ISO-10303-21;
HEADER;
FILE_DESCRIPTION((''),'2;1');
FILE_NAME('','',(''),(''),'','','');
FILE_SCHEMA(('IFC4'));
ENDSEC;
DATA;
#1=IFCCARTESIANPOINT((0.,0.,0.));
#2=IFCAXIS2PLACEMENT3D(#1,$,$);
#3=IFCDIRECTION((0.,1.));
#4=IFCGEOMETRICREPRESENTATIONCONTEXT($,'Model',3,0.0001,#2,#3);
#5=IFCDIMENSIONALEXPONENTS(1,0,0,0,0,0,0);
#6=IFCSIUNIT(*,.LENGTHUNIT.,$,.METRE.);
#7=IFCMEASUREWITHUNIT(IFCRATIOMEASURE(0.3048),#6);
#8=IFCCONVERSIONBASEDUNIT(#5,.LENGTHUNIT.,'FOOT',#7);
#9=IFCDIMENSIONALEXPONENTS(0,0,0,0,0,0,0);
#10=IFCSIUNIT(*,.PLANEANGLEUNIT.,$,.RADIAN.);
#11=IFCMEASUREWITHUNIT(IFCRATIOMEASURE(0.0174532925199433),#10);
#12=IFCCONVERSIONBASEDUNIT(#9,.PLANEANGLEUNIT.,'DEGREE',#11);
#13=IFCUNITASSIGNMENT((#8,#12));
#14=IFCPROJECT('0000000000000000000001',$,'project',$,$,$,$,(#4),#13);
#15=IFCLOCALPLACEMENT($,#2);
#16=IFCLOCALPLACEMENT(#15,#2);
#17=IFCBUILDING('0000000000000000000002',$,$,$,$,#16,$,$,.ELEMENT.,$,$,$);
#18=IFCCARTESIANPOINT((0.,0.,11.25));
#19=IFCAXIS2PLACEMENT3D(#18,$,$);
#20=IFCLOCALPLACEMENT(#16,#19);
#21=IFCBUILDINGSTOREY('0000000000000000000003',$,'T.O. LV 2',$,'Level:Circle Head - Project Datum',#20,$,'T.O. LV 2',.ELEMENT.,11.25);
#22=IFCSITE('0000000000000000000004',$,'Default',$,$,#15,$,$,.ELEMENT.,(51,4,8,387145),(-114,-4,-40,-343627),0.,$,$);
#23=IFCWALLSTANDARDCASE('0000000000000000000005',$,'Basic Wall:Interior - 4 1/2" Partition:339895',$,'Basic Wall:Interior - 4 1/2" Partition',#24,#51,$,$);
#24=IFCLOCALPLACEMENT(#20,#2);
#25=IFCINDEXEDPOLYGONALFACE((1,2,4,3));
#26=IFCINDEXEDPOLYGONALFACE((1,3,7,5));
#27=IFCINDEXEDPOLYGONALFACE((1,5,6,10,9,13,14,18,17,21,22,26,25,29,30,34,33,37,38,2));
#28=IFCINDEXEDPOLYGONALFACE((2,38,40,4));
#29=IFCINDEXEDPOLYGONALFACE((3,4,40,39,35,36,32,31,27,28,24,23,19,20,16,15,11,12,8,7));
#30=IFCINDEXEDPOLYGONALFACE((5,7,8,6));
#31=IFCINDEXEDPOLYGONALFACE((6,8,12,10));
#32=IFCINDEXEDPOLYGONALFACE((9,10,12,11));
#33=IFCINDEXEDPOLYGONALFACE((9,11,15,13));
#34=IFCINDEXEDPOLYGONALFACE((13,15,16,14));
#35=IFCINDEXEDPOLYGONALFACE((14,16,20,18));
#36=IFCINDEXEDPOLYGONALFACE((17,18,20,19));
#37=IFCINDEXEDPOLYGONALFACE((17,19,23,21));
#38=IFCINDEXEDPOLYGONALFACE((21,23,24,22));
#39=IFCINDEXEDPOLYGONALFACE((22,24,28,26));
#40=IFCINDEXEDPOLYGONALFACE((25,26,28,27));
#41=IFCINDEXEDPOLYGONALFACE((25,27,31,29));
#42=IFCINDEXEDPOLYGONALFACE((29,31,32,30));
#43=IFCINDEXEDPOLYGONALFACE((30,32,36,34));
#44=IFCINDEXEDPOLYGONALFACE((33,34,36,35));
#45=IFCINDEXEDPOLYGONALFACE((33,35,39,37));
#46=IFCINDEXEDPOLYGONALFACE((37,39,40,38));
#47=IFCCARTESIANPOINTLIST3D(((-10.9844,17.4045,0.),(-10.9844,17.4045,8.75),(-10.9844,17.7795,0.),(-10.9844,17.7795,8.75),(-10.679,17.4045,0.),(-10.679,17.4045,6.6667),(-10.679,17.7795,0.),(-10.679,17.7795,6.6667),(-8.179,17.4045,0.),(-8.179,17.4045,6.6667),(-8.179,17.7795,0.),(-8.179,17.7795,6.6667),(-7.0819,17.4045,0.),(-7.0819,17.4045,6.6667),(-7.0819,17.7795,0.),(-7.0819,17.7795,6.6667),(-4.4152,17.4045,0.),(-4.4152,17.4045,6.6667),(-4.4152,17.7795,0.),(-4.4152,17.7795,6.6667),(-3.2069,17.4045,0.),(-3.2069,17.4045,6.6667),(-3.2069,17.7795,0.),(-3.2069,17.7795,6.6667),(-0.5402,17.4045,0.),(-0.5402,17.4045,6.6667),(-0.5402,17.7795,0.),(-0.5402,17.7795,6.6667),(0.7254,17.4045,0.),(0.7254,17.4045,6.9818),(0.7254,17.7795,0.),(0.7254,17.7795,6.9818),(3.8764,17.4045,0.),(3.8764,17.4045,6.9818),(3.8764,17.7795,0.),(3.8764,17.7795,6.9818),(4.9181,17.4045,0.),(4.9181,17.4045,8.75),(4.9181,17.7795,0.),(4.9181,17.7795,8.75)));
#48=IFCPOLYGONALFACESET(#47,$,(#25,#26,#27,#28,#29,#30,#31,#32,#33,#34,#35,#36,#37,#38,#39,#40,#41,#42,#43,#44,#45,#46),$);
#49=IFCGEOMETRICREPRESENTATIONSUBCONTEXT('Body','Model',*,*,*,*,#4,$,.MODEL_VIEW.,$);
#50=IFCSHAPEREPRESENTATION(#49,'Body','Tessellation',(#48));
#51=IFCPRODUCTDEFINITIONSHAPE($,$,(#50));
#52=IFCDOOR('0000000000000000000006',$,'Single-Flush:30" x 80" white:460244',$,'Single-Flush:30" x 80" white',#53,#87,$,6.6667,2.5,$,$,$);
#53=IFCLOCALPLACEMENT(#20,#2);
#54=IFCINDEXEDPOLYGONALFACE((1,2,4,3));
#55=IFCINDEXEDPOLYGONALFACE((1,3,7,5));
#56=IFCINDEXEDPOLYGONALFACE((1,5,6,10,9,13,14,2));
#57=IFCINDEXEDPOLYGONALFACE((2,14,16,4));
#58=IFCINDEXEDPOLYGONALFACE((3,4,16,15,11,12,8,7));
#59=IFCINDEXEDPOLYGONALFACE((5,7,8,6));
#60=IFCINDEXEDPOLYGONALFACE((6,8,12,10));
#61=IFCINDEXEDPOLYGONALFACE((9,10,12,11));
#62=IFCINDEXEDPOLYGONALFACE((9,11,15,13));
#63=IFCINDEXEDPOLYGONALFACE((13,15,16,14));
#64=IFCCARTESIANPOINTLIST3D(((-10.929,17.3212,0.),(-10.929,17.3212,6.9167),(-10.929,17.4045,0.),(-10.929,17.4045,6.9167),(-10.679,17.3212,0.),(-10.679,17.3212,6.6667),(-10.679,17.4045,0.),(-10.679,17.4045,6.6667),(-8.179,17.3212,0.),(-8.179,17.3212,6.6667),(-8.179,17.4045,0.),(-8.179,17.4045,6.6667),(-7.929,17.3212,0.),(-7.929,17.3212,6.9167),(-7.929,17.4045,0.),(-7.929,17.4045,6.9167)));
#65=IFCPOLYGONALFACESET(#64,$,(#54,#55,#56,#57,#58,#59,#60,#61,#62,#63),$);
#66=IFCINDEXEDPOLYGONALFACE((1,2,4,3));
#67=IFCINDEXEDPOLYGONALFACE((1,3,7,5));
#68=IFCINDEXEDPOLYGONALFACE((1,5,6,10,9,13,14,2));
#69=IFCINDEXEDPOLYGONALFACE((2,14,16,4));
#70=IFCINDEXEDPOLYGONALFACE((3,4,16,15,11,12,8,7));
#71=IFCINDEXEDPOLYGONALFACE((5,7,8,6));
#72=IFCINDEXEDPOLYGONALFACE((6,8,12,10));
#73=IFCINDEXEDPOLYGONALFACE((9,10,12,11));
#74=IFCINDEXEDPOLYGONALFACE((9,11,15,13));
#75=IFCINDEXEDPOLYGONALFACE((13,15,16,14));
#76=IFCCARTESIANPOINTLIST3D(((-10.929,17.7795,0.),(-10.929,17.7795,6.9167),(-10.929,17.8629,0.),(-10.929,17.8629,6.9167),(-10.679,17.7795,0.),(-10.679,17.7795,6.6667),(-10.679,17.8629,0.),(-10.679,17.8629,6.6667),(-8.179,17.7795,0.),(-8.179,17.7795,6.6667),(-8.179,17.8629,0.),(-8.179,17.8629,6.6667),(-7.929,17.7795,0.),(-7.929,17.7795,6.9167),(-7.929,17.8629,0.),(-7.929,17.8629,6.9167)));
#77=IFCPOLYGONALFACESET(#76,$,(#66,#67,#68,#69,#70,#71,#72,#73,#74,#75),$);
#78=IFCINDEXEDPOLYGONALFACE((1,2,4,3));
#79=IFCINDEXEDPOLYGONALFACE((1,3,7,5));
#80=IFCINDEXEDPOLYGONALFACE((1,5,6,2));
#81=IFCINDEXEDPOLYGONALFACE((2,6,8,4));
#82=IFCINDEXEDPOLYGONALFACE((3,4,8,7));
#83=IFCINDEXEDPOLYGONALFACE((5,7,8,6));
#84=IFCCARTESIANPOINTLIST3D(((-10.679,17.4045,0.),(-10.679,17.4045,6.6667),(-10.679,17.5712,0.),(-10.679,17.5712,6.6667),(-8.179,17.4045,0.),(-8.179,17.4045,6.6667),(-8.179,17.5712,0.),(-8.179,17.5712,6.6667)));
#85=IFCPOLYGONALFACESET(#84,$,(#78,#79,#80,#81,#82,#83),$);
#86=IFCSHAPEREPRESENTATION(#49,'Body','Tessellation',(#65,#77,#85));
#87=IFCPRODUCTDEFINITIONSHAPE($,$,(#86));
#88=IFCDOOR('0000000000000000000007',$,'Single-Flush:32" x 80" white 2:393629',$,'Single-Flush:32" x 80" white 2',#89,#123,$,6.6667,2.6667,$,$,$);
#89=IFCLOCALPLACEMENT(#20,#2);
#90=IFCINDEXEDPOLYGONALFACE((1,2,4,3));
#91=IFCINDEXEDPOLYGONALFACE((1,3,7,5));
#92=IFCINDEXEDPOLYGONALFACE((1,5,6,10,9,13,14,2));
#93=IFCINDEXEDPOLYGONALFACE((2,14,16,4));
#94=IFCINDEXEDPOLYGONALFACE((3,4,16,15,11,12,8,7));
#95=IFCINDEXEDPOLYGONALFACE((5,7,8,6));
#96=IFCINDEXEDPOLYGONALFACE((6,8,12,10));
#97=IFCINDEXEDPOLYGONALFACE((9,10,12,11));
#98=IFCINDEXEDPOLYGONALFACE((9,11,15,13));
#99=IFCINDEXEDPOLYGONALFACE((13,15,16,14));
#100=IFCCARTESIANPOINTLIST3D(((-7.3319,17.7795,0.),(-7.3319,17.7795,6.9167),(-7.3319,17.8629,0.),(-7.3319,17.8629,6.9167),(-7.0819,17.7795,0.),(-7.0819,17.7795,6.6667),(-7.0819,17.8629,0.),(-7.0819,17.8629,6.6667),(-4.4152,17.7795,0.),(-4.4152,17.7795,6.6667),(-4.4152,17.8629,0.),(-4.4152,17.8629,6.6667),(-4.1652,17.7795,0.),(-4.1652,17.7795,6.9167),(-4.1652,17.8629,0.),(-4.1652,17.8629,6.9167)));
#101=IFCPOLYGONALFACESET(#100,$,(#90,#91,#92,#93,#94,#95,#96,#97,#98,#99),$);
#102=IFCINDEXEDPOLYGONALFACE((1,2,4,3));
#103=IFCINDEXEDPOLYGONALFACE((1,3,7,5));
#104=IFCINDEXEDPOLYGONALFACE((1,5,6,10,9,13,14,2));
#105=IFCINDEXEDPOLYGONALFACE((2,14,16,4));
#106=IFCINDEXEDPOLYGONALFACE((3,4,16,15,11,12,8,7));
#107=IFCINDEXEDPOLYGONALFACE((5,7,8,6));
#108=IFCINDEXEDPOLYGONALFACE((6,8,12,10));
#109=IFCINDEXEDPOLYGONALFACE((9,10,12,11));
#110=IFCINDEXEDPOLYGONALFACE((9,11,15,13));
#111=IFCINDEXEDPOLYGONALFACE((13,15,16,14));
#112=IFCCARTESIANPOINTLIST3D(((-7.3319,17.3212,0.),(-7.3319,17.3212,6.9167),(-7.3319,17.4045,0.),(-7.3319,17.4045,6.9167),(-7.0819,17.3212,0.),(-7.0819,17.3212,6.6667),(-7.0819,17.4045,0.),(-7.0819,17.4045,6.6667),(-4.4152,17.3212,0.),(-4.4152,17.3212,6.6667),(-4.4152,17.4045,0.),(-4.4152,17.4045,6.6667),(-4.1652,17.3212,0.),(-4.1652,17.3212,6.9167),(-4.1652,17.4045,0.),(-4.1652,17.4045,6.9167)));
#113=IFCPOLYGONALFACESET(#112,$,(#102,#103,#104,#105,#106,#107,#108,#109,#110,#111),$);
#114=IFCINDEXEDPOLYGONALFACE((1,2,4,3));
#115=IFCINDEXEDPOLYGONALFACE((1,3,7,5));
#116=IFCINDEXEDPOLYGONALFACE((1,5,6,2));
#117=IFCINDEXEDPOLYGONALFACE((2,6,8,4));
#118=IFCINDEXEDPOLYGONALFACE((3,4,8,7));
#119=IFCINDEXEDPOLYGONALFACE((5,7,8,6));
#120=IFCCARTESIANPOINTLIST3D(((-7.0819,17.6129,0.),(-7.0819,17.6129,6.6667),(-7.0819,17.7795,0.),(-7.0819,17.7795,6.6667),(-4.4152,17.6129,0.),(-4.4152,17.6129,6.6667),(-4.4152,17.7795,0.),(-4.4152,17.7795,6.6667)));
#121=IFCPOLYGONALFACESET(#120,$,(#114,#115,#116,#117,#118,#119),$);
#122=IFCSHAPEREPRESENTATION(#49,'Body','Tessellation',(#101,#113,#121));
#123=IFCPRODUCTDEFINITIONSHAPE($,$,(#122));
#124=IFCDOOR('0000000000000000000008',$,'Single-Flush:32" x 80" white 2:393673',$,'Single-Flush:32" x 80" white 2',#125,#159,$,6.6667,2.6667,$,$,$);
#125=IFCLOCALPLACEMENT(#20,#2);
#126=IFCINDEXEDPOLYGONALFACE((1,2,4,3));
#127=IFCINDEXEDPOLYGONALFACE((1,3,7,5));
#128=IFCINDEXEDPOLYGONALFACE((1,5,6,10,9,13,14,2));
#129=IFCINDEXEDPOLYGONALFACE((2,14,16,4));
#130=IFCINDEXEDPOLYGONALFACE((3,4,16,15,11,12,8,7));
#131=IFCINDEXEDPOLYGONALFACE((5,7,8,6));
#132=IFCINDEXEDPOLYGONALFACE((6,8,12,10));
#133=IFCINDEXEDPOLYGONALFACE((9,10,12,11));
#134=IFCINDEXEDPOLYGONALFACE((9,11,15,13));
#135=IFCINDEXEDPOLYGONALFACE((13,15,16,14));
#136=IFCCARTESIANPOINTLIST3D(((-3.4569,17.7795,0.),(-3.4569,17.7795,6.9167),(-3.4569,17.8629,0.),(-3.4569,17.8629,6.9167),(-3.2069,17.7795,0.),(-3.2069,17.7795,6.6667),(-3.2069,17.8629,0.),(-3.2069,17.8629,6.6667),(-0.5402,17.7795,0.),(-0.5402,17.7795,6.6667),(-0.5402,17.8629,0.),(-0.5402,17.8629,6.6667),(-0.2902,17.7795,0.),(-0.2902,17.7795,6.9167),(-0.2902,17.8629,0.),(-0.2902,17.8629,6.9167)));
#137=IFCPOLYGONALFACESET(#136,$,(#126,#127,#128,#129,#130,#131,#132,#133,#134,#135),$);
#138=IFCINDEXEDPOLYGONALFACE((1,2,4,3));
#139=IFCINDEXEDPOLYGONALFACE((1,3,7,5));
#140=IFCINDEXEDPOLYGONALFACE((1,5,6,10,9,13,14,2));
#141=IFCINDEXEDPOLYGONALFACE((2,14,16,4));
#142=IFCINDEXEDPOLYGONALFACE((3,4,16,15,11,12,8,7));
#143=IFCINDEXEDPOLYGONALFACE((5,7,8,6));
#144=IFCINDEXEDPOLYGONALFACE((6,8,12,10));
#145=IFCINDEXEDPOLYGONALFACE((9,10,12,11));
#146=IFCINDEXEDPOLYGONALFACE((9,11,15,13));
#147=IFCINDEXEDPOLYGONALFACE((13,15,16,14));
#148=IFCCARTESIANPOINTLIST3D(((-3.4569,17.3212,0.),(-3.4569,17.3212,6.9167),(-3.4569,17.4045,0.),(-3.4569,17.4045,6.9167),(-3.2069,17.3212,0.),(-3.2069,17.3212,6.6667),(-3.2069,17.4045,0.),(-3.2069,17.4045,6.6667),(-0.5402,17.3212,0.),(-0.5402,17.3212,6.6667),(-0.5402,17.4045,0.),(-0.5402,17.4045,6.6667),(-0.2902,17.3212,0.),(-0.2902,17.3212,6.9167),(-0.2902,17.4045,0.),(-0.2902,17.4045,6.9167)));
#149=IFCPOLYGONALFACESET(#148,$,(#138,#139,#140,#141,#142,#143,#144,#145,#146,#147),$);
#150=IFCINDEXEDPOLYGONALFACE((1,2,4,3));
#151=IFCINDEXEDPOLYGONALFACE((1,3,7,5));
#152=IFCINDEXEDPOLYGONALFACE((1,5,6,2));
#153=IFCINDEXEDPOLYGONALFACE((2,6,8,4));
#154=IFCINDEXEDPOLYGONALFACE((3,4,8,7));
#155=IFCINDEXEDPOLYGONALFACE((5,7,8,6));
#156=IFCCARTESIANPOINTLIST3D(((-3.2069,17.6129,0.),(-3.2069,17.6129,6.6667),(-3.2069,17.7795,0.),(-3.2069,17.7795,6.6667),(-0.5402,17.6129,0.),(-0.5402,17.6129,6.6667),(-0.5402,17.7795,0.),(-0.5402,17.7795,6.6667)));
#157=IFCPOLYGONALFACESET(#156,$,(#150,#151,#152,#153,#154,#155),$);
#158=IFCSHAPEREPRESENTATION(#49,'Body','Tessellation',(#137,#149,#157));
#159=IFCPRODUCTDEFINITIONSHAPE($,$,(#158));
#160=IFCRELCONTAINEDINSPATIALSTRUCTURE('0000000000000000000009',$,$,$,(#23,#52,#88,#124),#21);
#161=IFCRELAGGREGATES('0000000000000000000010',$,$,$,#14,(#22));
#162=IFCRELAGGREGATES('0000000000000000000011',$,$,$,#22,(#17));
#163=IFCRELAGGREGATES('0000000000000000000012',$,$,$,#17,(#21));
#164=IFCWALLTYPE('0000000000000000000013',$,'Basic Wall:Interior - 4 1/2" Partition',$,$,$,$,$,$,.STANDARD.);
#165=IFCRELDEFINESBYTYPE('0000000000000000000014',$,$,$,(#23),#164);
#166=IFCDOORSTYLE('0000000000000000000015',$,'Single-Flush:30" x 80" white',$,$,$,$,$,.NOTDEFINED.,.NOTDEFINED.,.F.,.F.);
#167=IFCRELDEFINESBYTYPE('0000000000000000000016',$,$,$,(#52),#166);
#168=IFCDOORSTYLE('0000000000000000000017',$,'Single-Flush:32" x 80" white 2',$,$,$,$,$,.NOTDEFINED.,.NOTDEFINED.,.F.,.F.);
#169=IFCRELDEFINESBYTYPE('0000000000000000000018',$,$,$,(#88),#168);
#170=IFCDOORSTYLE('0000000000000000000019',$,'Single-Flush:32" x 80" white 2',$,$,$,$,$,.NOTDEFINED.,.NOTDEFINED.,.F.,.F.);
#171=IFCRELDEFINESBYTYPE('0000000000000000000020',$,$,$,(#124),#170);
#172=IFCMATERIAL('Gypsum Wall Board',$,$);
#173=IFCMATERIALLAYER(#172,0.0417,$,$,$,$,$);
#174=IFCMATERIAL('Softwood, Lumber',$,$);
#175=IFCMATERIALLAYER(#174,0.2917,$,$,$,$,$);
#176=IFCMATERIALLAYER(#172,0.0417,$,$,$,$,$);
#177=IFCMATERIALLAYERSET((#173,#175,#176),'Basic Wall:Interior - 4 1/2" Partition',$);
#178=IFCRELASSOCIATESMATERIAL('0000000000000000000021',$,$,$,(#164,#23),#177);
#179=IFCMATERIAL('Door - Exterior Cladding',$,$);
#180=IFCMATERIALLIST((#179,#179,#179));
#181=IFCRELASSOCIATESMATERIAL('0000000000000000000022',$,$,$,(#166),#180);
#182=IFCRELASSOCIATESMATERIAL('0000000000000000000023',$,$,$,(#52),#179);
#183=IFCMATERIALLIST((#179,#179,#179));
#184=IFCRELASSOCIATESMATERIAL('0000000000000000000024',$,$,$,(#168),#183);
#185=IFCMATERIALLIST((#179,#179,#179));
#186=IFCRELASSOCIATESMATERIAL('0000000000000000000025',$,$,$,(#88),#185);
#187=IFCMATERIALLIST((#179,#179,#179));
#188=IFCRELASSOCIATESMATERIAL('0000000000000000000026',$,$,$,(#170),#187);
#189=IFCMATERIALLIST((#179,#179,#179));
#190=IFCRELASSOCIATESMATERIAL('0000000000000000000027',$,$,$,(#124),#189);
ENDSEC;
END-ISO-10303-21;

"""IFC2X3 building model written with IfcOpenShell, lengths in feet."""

from ifc_helpers import new_model, entity, si_unit, converted_unit, direction, frame, frame_2d, origin, origin_2d_with_axis, place, context, subcontext, project, spatial, polyline, rectangle, outline, extrude, source, transform, mapped, material, material_list, layer, layer_set, layer_usage, type_object, type_shapes, element, fill, save


model = new_model("IFC2X3")

# Units and contexts
model_context = context("Model", 3, precision=0.0001, world=origin(), true_north=direction((0.0, 1.0)))
body_context = subcontext(model_context, "Body", "Model", "MODEL_VIEW")
ifc_project = project(units=[converted_unit("LENGTHUNIT", "FOOT", entity("IfcRatioMeasure", 0.3048), si_unit("LENGTHUNIT", "METRE"), dimensions=[1, 0, 0, 0, 0, 0, 0]), converted_unit("PLANEANGLEUNIT", "DEGREE", entity("IfcRatioMeasure", 0.0174532925199433), si_unit("PLANEANGLEUNIT", "RADIAN"), dimensions=[0, 0, 0, 0, 0, 0, 0])], contexts=[model_context])

# Site, building, storey
site_placement = place(None, origin())
site = spatial("IfcSite", under=ifc_project, at=site_placement, Name="Default", CompositionType="ELEMENT", RefLatitude=(51, 4, 8, 387145), RefLongitude=(-114, -4, -40, -343627), RefElevation=0.0)
building_placement = place(site_placement, origin())
building = spatial("IfcBuilding", under=site, at=building_placement, CompositionType="ELEMENT")
storey_placement = place(building_placement, frame((0.0, 0.0, 11.25)))
storey = spatial("IfcBuildingStorey", under=building, at=storey_placement, Name="T.O. LV 2", ObjectType="Level:Circle Head - Project Datum", LongName="T.O. LV 2", CompositionType="ELEMENT", Elevation=11.25)

# Wall, openings, doors
ifc_material_1 = material(Name="Gypsum Wall Board")
ifc_layer_1 = layer(ifc_material_1, 0.0417)
ifc_material_2 = material(Name="Softwood, Lumber")
ifc_layer_2 = layer(ifc_material_2, 0.2917)
ifc_layer_3 = layer(ifc_material_1, 0.0417)
ifc_layer_set_1 = layer_set([ifc_layer_1, ifc_layer_2, ifc_layer_3], Name="Basic Wall:Interior - 4 1/2\" Partition")
ifc_layer_usage_1 = layer_usage(ifc_layer_set_1, "AXIS2", "NEGATIVE", 0.1875)
wall_type_1 = type_object("IfcWallType", Name="Basic Wall:Interior - 4 1/2\" Partition", PredefinedType="STANDARD", material=ifc_layer_set_1)
wall_1_placement = place(storey_placement, frame((4.9181, 17.592, 0.0), z_axis=(0.0, 0.0, 1.0), x_axis=(-1.0, 0.0, 0.0)))
wall_1 = element("IfcWallStandardCase", 1, at=wall_1_placement, inside=storey, type_object=wall_type_1, material=ifc_layer_usage_1, Name="Basic Wall:Interior - 4 1/2\" Partition:339895", ObjectType="Basic Wall:Interior - 4 1/2\" Partition", context=body_context, shape_type="SweptSolid", body=[
    extrude(rectangle(XDim=15.9025, YDim=0.375, at=frame_2d((7.9512, 0.0), x_axis=(1.0, 0.0))), origin(), (0.0, 0.0, 1.0), 8.75),
])
opening_1_placement = place(wall_1_placement, frame((12.0, 0.1875, 0.0)))
opening_1 = element("IfcOpeningElement", 2, at=opening_1_placement, cuts=wall_1, ObjectType="Opening", context=body_context, shape_type="SweptSolid", body=[
    extrude(rectangle(XDim=2.6667, YDim=6.6667, at=frame_2d((3.3333, 1.3333), x_axis=(0.0, 1.0))), frame((0.0, 0.0, 0.0), z_axis=(0.0, -1.0, 0.0), x_axis=(0.0, 0.0, 1.0)), (0.0, 0.0, 1.0), 0.375),
])
opening_2_placement = place(wall_1_placement, frame((8.125, 0.1875, 0.0)))
opening_2 = element("IfcOpeningElement", 3, at=opening_2_placement, cuts=wall_1, ObjectType="Opening", context=body_context, shape_type="SweptSolid", body=[
    extrude(rectangle(XDim=2.6667, YDim=6.6667, at=frame_2d((3.3333, 1.3333), x_axis=(0.0, -1.0))), frame((0.0, 0.0, 0.0), z_axis=(0.0, -1.0, 0.0), x_axis=(0.0, 0.0, 1.0)), (0.0, 0.0, 1.0), 0.375),
])
opening_3_placement = place(wall_1_placement, frame((1.0417, -0.1875, 0.0)))
element("IfcOpeningElement", 4, at=opening_3_placement, cuts=wall_1, ObjectType="Opening", context=body_context, shape_type="SweptSolid", body=[
    extrude(rectangle(XDim=6.9818, YDim=3.151, at=frame_2d((3.4909, 1.5755), x_axis=(1.0, 0.0))), frame((0.0, 0.0, 0.0), z_axis=(0.0, 1.0, 0.0), x_axis=(0.0, 0.0, 1.0)), (0.0, 0.0, 1.0), 0.375),
])
opening_4_placement = place(wall_1_placement, frame((13.0971, -0.1875, 0.0)))
opening_4 = element("IfcOpeningElement", 5, at=opening_4_placement, cuts=wall_1, ObjectType="Opening", context=body_context, shape_type="SweptSolid", body=[
    extrude(rectangle(XDim=2.5, YDim=6.6667, at=frame_2d((3.3333, 1.25), x_axis=(0.0, 1.0))), frame((0.0, 0.0, 0.0), z_axis=(0.0, 1.0, 0.0), x_axis=(0.0, 0.0, 1.0)), (0.0, 0.0, 1.0), 0.375),
])
ifc_material_3 = material(Name="Door - Exterior Cladding")
ifc_material_list_1 = material_list([ifc_material_3, ifc_material_3, ifc_material_3])
door_style_1 = type_object("IfcDoorStyle", Name="Single-Flush:30\" x 80\" white", ConstructionType="NOTDEFINED", OperationType="NOTDEFINED", ParameterTakesPrecedence=False, Sizeable=False, material=ifc_material_list_1)
shared_shape_1 = source(origin(), body_context, "Body", "SweptSolid", [
    extrude(outline(polyline([(-1.5, -3.5208), (1.5, -3.5208), (1.5, 3.3958), (1.25, 3.3958), (1.25, -3.2708), (-1.25, -3.2708), (-1.25, 3.3958), (-1.5, 3.3958), (-1.5, -3.5208)])), frame((1.25, 0.375, 3.3958), z_axis=(0.0, 1.0, 0.0), x_axis=(1.0, 0.0, 0.0)), (0.0, 0.0, 1.0), 0.0833),
    extrude(outline(polyline([(-3.5208, -1.5), (3.3958, -1.5), (3.3958, -1.25), (-3.2708, -1.25), (-3.2708, 1.25), (3.3958, 1.25), (3.3958, 1.5), (-3.5208, 1.5), (-3.5208, -1.5)])), frame((1.25, -0.0833, 3.3958), z_axis=(0.0, 1.0, 0.0), x_axis=(0.0, 0.0, -1.0)), (0.0, 0.0, 1.0), 0.0833),
    extrude(rectangle(XDim=0.1667, YDim=2.5, at=frame_2d((0.0, 0.0), x_axis=(1.0, 0.0))), frame((1.25, 0.2917, 0.0), z_axis=(0.0, 0.0, 1.0), x_axis=(0.0, 1.0, 0.0)), (0.0, 0.0, 1.0), 6.6667),
])
type_shapes(door_style_1, [shared_shape_1])
door_1_placement = place(opening_4_placement, origin())
door_1 = element("IfcDoor", 6, at=door_1_placement, inside=storey, type_object=door_style_1, material=ifc_material_3, Name="Single-Flush:30\" x 80\" white:460244", ObjectType="Single-Flush:30\" x 80\" white", OverallHeight=6.6667, OverallWidth=2.5, context=body_context, shape_type="MappedRepresentation", body=[
    mapped(shared_shape_1, transform((0.0, 0.0, 0.0), scale=1.0)),
])
fill(opening_4, door_1)
ifc_material_list_2 = material_list([ifc_material_3, ifc_material_3, ifc_material_3])
ifc_material_list_3 = material_list([ifc_material_3, ifc_material_3, ifc_material_3])
door_style_2 = type_object("IfcDoorStyle", Name="Single-Flush:32\" x 80\" white 2", ConstructionType="NOTDEFINED", OperationType="NOTDEFINED", ParameterTakesPrecedence=False, Sizeable=False, material=ifc_material_list_3)
shared_shape_2 = source(origin(), body_context, "Body", "SweptSolid", [
    extrude(outline(polyline([(-1.5833, -3.5208), (1.5833, -3.5208), (1.5833, 3.3958), (1.3333, 3.3958), (1.3333, -3.2708), (-1.3333, -3.2708), (-1.3333, 3.3958), (-1.5833, 3.3958), (-1.5833, -3.5208)])), frame((1.3333, 0.375, 3.3958), z_axis=(0.0, 1.0, 0.0), x_axis=(1.0, 0.0, 0.0)), (0.0, 0.0, 1.0), 0.0833),
    extrude(outline(polyline([(-3.5208, -1.5833), (3.3958, -1.5833), (3.3958, -1.3333), (-3.2708, -1.3333), (-3.2708, 1.3333), (3.3958, 1.3333), (3.3958, 1.5833), (-3.5208, 1.5833), (-3.5208, -1.5833)])), frame((1.3333, -0.0833, 3.3958), z_axis=(0.0, 1.0, 0.0), x_axis=(0.0, 0.0, -1.0)), (0.0, 0.0, 1.0), 0.0833),
    extrude(rectangle(XDim=0.1667, YDim=2.6667, at=frame_2d((0.0, 0.0), x_axis=(1.0, 0.0))), frame((1.3333, 0.2917, 0.0), z_axis=(0.0, 0.0, 1.0), x_axis=(0.0, 1.0, 0.0)), (0.0, 0.0, 1.0), 6.6667),
])
type_shapes(door_style_2, [shared_shape_2])
door_2_placement = place(opening_1_placement, frame((0.0, 0.0, 0.0), z_axis=(0.0, 0.0, 1.0), x_axis=(-1.0, 0.0, 0.0)))
door_2 = element("IfcDoor", 7, at=door_2_placement, inside=storey, type_object=door_style_2, material=ifc_material_list_2, Name="Single-Flush:32\" x 80\" white 2:393629", ObjectType="Single-Flush:32\" x 80\" white 2", OverallHeight=6.6667, OverallWidth=2.6667, context=body_context, shape_type="MappedRepresentation", body=[
    mapped(shared_shape_2, transform((0.0, 0.0, 0.0), scale=1.0)),
])
fill(opening_1, door_2)
ifc_material_list_4 = material_list([ifc_material_3, ifc_material_3, ifc_material_3])
ifc_material_list_5 = material_list([ifc_material_3, ifc_material_3, ifc_material_3])
door_style_3 = type_object("IfcDoorStyle", Name="Single-Flush:32\" x 80\" white 2", ConstructionType="NOTDEFINED", OperationType="NOTDEFINED", ParameterTakesPrecedence=False, Sizeable=False, material=ifc_material_list_5)
shared_shape_3 = source(origin(), body_context, "Body", "SweptSolid", [
    extrude(outline(polyline([(-1.5833, -3.5208), (1.5833, -3.5208), (1.5833, 3.3958), (1.3333, 3.3958), (1.3333, -3.2708), (-1.3333, -3.2708), (-1.3333, 3.3958), (-1.5833, 3.3958), (-1.5833, -3.5208)])), frame((1.3333, 0.4583, 3.3958), z_axis=(0.0, -1.0, 0.0), x_axis=(-1.0, 0.0, 0.0)), (0.0, 0.0, 1.0), 0.0833),
    extrude(outline(polyline([(-3.5208, -1.5833), (3.3958, -1.5833), (3.3958, -1.3333), (-3.2708, -1.3333), (-3.2708, 1.3333), (3.3958, 1.3333), (3.3958, 1.5833), (-3.5208, 1.5833), (-3.5208, -1.5833)])), frame((1.3333, 0.0, 3.3958), z_axis=(0.0, -1.0, 0.0), x_axis=(0.0, 0.0, -1.0)), (0.0, 0.0, 1.0), 0.0833),
    extrude(rectangle(XDim=2.6667, YDim=0.1667, at=origin_2d_with_axis()), frame((1.3333, 0.2917, 0.0)), (0.0, 0.0, 1.0), 6.6667),
])
type_shapes(door_style_3, [shared_shape_3])
door_3_placement = place(opening_2_placement, frame((0.0, 0.0, 0.0), z_axis=(0.0, 0.0, 1.0), x_axis=(-1.0, 0.0, 0.0)))
door_3 = element("IfcDoor", 8, at=door_3_placement, inside=storey, type_object=door_style_3, material=ifc_material_list_4, Name="Single-Flush:32\" x 80\" white 2:393673", ObjectType="Single-Flush:32\" x 80\" white 2", OverallHeight=6.6667, OverallWidth=2.6667, context=body_context, shape_type="MappedRepresentation", body=[
    mapped(shared_shape_3, transform((0.0, 0.0, 0.0), scale=1.0)),
])
fill(opening_2, door_3)

save(model, "model.ifc")
